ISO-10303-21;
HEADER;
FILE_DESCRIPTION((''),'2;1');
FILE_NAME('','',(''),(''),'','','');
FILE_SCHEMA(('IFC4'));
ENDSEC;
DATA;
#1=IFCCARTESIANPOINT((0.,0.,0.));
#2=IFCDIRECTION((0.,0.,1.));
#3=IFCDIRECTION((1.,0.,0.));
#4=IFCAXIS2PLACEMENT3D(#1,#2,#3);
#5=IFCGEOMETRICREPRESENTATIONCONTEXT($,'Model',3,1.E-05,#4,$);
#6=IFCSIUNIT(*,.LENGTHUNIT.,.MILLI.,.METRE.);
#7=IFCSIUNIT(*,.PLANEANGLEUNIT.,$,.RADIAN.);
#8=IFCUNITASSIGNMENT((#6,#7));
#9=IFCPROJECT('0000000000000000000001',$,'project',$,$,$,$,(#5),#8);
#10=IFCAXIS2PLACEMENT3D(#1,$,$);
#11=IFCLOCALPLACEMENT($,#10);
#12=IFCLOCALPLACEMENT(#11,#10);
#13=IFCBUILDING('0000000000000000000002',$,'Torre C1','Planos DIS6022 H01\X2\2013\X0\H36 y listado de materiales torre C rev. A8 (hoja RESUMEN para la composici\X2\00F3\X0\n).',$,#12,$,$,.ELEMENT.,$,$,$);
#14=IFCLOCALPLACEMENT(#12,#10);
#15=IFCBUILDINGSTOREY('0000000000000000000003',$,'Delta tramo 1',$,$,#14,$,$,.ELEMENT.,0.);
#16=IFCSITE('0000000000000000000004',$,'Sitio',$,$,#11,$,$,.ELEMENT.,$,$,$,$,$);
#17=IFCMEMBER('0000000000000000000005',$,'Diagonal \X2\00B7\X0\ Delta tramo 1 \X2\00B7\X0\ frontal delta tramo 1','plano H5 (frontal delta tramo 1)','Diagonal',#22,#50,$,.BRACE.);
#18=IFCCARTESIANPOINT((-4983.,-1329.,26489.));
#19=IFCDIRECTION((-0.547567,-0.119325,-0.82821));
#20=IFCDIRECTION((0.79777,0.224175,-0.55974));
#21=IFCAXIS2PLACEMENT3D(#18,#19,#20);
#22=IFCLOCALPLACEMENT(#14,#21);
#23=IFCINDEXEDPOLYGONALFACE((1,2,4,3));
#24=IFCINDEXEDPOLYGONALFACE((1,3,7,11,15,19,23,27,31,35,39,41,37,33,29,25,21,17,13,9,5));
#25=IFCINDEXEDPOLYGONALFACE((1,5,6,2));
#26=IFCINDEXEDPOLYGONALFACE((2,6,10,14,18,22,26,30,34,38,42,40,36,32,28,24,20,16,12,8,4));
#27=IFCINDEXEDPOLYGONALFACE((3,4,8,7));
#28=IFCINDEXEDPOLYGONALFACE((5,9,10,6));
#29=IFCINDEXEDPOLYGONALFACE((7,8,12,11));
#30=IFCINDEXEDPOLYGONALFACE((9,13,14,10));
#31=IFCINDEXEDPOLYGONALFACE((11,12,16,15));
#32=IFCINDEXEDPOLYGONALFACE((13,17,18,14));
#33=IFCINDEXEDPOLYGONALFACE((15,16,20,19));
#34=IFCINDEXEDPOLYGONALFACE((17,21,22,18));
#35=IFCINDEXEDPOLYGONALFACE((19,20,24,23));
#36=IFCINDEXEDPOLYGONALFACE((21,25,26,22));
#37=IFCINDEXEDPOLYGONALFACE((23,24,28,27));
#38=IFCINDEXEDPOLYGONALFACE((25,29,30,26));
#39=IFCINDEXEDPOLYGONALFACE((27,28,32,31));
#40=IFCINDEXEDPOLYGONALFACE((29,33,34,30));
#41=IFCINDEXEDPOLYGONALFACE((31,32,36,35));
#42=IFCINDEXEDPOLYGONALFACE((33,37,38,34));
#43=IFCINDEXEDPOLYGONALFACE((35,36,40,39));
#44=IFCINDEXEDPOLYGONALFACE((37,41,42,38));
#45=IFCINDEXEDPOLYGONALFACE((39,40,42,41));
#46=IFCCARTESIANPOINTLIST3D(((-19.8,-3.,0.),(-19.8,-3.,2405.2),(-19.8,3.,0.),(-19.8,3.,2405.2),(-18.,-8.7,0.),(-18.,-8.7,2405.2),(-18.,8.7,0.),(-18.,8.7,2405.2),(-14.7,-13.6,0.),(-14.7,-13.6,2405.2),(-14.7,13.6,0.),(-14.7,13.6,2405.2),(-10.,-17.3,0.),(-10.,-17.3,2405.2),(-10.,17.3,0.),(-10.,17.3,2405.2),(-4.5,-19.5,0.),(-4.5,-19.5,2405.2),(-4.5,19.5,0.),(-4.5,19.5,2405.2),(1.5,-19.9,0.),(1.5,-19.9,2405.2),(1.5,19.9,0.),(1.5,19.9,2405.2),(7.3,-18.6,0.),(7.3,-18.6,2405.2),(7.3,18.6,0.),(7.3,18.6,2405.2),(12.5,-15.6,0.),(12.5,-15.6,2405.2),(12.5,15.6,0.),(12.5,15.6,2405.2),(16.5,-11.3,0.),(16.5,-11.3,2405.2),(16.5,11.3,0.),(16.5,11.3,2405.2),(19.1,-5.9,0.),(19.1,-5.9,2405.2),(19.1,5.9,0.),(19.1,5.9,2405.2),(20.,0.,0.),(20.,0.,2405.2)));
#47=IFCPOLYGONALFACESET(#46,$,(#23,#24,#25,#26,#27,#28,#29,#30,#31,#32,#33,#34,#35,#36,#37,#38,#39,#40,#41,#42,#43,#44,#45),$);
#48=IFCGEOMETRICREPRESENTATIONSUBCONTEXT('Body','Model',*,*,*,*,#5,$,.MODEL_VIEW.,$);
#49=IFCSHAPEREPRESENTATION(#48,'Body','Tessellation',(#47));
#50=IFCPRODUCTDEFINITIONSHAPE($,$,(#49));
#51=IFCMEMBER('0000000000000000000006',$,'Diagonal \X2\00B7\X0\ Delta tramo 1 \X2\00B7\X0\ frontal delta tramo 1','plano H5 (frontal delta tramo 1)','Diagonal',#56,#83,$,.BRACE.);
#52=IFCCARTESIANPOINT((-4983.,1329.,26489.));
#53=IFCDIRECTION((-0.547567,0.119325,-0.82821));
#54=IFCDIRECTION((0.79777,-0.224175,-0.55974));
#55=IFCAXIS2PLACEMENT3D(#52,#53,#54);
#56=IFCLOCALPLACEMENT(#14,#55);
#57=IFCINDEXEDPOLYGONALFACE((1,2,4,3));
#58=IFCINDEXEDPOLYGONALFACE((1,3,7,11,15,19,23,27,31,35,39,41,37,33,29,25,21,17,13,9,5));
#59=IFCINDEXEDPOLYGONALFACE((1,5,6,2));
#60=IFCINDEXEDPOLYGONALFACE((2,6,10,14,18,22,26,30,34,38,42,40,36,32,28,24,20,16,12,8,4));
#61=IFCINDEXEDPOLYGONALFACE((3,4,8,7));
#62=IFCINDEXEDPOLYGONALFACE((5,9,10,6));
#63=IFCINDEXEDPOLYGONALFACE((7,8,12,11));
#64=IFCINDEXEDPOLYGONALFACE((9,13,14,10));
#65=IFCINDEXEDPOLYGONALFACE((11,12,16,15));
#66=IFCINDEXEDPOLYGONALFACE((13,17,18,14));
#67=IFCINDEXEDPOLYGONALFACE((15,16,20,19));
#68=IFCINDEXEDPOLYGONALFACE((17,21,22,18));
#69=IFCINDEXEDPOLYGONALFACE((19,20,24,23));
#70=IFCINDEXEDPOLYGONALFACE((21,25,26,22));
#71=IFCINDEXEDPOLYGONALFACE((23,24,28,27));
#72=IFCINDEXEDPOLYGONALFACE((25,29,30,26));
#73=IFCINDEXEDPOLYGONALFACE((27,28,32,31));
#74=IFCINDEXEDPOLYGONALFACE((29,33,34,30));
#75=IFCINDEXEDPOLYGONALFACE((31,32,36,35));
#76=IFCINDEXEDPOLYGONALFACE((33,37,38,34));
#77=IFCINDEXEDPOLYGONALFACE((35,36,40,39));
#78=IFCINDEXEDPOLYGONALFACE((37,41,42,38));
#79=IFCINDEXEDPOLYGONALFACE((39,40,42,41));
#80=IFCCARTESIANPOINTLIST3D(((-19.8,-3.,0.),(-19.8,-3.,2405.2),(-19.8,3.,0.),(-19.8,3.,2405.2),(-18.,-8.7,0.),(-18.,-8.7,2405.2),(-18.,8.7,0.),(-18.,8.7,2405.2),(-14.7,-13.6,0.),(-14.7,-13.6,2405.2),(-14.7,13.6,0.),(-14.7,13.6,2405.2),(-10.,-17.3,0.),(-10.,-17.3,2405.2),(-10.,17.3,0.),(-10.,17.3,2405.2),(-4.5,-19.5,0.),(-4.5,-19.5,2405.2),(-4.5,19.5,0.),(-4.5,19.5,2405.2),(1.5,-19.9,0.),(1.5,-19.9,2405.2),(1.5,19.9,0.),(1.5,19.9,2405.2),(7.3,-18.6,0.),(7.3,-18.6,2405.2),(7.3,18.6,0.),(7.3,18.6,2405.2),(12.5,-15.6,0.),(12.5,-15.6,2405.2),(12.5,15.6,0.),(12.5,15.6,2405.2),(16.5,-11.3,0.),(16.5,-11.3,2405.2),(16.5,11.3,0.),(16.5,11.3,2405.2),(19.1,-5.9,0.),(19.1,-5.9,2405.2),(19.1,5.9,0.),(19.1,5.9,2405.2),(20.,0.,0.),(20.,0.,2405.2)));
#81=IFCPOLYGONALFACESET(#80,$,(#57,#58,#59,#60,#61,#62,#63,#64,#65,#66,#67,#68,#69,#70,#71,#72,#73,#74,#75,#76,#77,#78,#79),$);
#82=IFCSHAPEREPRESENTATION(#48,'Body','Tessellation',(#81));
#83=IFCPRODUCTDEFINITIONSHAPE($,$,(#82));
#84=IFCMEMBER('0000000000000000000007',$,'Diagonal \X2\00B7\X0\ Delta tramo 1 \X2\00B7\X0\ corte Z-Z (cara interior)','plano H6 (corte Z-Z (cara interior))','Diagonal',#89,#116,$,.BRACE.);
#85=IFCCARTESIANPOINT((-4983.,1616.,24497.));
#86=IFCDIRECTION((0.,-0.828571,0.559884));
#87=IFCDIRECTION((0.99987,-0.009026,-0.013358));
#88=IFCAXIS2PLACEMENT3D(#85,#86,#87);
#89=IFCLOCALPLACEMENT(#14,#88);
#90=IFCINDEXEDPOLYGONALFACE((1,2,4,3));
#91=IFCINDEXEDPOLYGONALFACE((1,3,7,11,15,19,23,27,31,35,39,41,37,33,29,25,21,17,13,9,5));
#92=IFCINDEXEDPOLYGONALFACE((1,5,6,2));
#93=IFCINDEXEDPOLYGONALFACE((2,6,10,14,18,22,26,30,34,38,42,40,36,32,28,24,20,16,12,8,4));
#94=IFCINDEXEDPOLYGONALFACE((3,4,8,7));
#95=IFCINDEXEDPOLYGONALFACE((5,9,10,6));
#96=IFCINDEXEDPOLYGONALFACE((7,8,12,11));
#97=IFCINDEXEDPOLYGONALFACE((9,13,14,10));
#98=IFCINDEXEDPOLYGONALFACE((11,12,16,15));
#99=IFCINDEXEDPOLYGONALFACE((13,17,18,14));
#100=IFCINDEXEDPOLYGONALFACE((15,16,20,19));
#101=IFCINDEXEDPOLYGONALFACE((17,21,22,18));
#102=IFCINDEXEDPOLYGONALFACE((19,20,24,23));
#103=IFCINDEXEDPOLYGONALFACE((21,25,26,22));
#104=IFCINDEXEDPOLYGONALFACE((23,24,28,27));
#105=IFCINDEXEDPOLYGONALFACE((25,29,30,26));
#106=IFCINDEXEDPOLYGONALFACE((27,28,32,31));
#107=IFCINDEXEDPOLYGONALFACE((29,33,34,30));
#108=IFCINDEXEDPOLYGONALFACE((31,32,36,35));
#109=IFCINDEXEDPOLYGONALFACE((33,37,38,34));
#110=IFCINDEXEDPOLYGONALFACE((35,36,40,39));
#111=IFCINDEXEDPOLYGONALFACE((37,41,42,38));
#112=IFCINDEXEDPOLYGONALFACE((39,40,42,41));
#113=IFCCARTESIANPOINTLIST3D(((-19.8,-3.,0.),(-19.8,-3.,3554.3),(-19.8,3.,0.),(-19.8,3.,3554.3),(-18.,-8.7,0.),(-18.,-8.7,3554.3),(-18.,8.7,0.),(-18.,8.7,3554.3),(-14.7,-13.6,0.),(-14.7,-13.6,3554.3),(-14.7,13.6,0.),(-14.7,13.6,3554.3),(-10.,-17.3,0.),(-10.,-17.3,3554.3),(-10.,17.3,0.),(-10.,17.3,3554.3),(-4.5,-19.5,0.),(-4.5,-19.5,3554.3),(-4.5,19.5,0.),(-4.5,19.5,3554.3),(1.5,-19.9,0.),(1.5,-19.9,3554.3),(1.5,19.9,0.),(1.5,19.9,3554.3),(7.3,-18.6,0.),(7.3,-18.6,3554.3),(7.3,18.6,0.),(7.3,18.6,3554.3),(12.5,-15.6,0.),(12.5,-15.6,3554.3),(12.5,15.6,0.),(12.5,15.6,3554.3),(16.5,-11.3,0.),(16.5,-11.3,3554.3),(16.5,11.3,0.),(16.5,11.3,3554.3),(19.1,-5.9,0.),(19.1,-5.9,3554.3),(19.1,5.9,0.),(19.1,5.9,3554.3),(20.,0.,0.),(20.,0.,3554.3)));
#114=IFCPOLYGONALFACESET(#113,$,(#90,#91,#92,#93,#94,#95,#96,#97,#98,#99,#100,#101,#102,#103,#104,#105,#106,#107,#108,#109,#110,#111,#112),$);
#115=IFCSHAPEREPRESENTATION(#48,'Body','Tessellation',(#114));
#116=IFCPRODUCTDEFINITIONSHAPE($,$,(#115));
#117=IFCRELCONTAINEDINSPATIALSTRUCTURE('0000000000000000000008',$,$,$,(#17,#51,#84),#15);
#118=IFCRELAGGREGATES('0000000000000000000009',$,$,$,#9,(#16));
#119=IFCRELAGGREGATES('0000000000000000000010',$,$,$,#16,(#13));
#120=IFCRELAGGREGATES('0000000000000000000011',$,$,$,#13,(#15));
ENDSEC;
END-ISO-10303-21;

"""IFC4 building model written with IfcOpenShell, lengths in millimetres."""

from ifc_helpers import new_model, si_unit, frame, origin, origin_with_axes, place, context, subcontext, project, spatial, circle, extrude, element, save


model = new_model("IFC4")

# Units and contexts
model_context = context("Model", 3, precision=1e-05, world=origin_with_axes())
body_context = subcontext(model_context, "Body", "Model", "MODEL_VIEW")
ifc_project = project(units=[si_unit("LENGTHUNIT", "METRE", prefix="MILLI"), si_unit("PLANEANGLEUNIT", "RADIAN")], contexts=[model_context])

# Site, building, storey
site_placement = place(None, origin())
site = spatial("IfcSite", under=ifc_project, at=site_placement, Name="Sitio", CompositionType="ELEMENT")
building_placement = place(site_placement, origin())
building = spatial("IfcBuilding", under=site, at=building_placement, Name="Torre C1", Description="Planos DIS6022 H01–H36 y listado de materiales torre C rev. A8 (hoja RESUMEN para la composición).", CompositionType="ELEMENT")
storey_placement = place(building_placement, origin())
storey = spatial("IfcBuildingStorey", under=building, at=storey_placement, Name="Delta tramo 1", CompositionType="ELEMENT", Elevation=0.0)

# Members
for number, where, z_axis, x_axis, name in (
    (1, (-4983.0, -1329.0, 26489.0), (-0.547567, -0.119325, -0.82821), (0.79777, 0.224175, -0.55974), "Diagonal · Delta tramo 1 · frontal delta tramo 1"),
    (2, (-4983.0, 1329.0, 26489.0), (-0.547567, 0.119325, -0.82821), (0.79777, -0.224175, -0.55974), "Diagonal · Delta tramo 1 · frontal delta tramo 1"),
):
    element("IfcMember", number, at=place(storey_placement, frame(where, z_axis=z_axis, x_axis=x_axis)), inside=storey, Name=name, Description="plano H5 (frontal delta tramo 1)", ObjectType="Diagonal", PredefinedType="BRACE", context=body_context, shape_type="SweptSolid", body=[
        extrude(circle(Radius=20.0), None, (0.0, 0.0, 1.0), 2405.2),
    ])
member_1_placement = place(storey_placement, frame((-4983.0, 1616.0, 24497.0), z_axis=(0.0, -0.828571, 0.559884), x_axis=(0.99987, -0.009026, -0.013358)))
element("IfcMember", 3, at=member_1_placement, inside=storey, Name="Diagonal · Delta tramo 1 · corte Z-Z (cara interior)", Description="plano H6 (corte Z-Z (cara interior))", ObjectType="Diagonal", PredefinedType="BRACE", context=body_context, shape_type="SweptSolid", body=[
    extrude(circle(Radius=20.0), None, (0.0, 0.0, 1.0), 3554.3),
])

save(model, "model.ifc")
